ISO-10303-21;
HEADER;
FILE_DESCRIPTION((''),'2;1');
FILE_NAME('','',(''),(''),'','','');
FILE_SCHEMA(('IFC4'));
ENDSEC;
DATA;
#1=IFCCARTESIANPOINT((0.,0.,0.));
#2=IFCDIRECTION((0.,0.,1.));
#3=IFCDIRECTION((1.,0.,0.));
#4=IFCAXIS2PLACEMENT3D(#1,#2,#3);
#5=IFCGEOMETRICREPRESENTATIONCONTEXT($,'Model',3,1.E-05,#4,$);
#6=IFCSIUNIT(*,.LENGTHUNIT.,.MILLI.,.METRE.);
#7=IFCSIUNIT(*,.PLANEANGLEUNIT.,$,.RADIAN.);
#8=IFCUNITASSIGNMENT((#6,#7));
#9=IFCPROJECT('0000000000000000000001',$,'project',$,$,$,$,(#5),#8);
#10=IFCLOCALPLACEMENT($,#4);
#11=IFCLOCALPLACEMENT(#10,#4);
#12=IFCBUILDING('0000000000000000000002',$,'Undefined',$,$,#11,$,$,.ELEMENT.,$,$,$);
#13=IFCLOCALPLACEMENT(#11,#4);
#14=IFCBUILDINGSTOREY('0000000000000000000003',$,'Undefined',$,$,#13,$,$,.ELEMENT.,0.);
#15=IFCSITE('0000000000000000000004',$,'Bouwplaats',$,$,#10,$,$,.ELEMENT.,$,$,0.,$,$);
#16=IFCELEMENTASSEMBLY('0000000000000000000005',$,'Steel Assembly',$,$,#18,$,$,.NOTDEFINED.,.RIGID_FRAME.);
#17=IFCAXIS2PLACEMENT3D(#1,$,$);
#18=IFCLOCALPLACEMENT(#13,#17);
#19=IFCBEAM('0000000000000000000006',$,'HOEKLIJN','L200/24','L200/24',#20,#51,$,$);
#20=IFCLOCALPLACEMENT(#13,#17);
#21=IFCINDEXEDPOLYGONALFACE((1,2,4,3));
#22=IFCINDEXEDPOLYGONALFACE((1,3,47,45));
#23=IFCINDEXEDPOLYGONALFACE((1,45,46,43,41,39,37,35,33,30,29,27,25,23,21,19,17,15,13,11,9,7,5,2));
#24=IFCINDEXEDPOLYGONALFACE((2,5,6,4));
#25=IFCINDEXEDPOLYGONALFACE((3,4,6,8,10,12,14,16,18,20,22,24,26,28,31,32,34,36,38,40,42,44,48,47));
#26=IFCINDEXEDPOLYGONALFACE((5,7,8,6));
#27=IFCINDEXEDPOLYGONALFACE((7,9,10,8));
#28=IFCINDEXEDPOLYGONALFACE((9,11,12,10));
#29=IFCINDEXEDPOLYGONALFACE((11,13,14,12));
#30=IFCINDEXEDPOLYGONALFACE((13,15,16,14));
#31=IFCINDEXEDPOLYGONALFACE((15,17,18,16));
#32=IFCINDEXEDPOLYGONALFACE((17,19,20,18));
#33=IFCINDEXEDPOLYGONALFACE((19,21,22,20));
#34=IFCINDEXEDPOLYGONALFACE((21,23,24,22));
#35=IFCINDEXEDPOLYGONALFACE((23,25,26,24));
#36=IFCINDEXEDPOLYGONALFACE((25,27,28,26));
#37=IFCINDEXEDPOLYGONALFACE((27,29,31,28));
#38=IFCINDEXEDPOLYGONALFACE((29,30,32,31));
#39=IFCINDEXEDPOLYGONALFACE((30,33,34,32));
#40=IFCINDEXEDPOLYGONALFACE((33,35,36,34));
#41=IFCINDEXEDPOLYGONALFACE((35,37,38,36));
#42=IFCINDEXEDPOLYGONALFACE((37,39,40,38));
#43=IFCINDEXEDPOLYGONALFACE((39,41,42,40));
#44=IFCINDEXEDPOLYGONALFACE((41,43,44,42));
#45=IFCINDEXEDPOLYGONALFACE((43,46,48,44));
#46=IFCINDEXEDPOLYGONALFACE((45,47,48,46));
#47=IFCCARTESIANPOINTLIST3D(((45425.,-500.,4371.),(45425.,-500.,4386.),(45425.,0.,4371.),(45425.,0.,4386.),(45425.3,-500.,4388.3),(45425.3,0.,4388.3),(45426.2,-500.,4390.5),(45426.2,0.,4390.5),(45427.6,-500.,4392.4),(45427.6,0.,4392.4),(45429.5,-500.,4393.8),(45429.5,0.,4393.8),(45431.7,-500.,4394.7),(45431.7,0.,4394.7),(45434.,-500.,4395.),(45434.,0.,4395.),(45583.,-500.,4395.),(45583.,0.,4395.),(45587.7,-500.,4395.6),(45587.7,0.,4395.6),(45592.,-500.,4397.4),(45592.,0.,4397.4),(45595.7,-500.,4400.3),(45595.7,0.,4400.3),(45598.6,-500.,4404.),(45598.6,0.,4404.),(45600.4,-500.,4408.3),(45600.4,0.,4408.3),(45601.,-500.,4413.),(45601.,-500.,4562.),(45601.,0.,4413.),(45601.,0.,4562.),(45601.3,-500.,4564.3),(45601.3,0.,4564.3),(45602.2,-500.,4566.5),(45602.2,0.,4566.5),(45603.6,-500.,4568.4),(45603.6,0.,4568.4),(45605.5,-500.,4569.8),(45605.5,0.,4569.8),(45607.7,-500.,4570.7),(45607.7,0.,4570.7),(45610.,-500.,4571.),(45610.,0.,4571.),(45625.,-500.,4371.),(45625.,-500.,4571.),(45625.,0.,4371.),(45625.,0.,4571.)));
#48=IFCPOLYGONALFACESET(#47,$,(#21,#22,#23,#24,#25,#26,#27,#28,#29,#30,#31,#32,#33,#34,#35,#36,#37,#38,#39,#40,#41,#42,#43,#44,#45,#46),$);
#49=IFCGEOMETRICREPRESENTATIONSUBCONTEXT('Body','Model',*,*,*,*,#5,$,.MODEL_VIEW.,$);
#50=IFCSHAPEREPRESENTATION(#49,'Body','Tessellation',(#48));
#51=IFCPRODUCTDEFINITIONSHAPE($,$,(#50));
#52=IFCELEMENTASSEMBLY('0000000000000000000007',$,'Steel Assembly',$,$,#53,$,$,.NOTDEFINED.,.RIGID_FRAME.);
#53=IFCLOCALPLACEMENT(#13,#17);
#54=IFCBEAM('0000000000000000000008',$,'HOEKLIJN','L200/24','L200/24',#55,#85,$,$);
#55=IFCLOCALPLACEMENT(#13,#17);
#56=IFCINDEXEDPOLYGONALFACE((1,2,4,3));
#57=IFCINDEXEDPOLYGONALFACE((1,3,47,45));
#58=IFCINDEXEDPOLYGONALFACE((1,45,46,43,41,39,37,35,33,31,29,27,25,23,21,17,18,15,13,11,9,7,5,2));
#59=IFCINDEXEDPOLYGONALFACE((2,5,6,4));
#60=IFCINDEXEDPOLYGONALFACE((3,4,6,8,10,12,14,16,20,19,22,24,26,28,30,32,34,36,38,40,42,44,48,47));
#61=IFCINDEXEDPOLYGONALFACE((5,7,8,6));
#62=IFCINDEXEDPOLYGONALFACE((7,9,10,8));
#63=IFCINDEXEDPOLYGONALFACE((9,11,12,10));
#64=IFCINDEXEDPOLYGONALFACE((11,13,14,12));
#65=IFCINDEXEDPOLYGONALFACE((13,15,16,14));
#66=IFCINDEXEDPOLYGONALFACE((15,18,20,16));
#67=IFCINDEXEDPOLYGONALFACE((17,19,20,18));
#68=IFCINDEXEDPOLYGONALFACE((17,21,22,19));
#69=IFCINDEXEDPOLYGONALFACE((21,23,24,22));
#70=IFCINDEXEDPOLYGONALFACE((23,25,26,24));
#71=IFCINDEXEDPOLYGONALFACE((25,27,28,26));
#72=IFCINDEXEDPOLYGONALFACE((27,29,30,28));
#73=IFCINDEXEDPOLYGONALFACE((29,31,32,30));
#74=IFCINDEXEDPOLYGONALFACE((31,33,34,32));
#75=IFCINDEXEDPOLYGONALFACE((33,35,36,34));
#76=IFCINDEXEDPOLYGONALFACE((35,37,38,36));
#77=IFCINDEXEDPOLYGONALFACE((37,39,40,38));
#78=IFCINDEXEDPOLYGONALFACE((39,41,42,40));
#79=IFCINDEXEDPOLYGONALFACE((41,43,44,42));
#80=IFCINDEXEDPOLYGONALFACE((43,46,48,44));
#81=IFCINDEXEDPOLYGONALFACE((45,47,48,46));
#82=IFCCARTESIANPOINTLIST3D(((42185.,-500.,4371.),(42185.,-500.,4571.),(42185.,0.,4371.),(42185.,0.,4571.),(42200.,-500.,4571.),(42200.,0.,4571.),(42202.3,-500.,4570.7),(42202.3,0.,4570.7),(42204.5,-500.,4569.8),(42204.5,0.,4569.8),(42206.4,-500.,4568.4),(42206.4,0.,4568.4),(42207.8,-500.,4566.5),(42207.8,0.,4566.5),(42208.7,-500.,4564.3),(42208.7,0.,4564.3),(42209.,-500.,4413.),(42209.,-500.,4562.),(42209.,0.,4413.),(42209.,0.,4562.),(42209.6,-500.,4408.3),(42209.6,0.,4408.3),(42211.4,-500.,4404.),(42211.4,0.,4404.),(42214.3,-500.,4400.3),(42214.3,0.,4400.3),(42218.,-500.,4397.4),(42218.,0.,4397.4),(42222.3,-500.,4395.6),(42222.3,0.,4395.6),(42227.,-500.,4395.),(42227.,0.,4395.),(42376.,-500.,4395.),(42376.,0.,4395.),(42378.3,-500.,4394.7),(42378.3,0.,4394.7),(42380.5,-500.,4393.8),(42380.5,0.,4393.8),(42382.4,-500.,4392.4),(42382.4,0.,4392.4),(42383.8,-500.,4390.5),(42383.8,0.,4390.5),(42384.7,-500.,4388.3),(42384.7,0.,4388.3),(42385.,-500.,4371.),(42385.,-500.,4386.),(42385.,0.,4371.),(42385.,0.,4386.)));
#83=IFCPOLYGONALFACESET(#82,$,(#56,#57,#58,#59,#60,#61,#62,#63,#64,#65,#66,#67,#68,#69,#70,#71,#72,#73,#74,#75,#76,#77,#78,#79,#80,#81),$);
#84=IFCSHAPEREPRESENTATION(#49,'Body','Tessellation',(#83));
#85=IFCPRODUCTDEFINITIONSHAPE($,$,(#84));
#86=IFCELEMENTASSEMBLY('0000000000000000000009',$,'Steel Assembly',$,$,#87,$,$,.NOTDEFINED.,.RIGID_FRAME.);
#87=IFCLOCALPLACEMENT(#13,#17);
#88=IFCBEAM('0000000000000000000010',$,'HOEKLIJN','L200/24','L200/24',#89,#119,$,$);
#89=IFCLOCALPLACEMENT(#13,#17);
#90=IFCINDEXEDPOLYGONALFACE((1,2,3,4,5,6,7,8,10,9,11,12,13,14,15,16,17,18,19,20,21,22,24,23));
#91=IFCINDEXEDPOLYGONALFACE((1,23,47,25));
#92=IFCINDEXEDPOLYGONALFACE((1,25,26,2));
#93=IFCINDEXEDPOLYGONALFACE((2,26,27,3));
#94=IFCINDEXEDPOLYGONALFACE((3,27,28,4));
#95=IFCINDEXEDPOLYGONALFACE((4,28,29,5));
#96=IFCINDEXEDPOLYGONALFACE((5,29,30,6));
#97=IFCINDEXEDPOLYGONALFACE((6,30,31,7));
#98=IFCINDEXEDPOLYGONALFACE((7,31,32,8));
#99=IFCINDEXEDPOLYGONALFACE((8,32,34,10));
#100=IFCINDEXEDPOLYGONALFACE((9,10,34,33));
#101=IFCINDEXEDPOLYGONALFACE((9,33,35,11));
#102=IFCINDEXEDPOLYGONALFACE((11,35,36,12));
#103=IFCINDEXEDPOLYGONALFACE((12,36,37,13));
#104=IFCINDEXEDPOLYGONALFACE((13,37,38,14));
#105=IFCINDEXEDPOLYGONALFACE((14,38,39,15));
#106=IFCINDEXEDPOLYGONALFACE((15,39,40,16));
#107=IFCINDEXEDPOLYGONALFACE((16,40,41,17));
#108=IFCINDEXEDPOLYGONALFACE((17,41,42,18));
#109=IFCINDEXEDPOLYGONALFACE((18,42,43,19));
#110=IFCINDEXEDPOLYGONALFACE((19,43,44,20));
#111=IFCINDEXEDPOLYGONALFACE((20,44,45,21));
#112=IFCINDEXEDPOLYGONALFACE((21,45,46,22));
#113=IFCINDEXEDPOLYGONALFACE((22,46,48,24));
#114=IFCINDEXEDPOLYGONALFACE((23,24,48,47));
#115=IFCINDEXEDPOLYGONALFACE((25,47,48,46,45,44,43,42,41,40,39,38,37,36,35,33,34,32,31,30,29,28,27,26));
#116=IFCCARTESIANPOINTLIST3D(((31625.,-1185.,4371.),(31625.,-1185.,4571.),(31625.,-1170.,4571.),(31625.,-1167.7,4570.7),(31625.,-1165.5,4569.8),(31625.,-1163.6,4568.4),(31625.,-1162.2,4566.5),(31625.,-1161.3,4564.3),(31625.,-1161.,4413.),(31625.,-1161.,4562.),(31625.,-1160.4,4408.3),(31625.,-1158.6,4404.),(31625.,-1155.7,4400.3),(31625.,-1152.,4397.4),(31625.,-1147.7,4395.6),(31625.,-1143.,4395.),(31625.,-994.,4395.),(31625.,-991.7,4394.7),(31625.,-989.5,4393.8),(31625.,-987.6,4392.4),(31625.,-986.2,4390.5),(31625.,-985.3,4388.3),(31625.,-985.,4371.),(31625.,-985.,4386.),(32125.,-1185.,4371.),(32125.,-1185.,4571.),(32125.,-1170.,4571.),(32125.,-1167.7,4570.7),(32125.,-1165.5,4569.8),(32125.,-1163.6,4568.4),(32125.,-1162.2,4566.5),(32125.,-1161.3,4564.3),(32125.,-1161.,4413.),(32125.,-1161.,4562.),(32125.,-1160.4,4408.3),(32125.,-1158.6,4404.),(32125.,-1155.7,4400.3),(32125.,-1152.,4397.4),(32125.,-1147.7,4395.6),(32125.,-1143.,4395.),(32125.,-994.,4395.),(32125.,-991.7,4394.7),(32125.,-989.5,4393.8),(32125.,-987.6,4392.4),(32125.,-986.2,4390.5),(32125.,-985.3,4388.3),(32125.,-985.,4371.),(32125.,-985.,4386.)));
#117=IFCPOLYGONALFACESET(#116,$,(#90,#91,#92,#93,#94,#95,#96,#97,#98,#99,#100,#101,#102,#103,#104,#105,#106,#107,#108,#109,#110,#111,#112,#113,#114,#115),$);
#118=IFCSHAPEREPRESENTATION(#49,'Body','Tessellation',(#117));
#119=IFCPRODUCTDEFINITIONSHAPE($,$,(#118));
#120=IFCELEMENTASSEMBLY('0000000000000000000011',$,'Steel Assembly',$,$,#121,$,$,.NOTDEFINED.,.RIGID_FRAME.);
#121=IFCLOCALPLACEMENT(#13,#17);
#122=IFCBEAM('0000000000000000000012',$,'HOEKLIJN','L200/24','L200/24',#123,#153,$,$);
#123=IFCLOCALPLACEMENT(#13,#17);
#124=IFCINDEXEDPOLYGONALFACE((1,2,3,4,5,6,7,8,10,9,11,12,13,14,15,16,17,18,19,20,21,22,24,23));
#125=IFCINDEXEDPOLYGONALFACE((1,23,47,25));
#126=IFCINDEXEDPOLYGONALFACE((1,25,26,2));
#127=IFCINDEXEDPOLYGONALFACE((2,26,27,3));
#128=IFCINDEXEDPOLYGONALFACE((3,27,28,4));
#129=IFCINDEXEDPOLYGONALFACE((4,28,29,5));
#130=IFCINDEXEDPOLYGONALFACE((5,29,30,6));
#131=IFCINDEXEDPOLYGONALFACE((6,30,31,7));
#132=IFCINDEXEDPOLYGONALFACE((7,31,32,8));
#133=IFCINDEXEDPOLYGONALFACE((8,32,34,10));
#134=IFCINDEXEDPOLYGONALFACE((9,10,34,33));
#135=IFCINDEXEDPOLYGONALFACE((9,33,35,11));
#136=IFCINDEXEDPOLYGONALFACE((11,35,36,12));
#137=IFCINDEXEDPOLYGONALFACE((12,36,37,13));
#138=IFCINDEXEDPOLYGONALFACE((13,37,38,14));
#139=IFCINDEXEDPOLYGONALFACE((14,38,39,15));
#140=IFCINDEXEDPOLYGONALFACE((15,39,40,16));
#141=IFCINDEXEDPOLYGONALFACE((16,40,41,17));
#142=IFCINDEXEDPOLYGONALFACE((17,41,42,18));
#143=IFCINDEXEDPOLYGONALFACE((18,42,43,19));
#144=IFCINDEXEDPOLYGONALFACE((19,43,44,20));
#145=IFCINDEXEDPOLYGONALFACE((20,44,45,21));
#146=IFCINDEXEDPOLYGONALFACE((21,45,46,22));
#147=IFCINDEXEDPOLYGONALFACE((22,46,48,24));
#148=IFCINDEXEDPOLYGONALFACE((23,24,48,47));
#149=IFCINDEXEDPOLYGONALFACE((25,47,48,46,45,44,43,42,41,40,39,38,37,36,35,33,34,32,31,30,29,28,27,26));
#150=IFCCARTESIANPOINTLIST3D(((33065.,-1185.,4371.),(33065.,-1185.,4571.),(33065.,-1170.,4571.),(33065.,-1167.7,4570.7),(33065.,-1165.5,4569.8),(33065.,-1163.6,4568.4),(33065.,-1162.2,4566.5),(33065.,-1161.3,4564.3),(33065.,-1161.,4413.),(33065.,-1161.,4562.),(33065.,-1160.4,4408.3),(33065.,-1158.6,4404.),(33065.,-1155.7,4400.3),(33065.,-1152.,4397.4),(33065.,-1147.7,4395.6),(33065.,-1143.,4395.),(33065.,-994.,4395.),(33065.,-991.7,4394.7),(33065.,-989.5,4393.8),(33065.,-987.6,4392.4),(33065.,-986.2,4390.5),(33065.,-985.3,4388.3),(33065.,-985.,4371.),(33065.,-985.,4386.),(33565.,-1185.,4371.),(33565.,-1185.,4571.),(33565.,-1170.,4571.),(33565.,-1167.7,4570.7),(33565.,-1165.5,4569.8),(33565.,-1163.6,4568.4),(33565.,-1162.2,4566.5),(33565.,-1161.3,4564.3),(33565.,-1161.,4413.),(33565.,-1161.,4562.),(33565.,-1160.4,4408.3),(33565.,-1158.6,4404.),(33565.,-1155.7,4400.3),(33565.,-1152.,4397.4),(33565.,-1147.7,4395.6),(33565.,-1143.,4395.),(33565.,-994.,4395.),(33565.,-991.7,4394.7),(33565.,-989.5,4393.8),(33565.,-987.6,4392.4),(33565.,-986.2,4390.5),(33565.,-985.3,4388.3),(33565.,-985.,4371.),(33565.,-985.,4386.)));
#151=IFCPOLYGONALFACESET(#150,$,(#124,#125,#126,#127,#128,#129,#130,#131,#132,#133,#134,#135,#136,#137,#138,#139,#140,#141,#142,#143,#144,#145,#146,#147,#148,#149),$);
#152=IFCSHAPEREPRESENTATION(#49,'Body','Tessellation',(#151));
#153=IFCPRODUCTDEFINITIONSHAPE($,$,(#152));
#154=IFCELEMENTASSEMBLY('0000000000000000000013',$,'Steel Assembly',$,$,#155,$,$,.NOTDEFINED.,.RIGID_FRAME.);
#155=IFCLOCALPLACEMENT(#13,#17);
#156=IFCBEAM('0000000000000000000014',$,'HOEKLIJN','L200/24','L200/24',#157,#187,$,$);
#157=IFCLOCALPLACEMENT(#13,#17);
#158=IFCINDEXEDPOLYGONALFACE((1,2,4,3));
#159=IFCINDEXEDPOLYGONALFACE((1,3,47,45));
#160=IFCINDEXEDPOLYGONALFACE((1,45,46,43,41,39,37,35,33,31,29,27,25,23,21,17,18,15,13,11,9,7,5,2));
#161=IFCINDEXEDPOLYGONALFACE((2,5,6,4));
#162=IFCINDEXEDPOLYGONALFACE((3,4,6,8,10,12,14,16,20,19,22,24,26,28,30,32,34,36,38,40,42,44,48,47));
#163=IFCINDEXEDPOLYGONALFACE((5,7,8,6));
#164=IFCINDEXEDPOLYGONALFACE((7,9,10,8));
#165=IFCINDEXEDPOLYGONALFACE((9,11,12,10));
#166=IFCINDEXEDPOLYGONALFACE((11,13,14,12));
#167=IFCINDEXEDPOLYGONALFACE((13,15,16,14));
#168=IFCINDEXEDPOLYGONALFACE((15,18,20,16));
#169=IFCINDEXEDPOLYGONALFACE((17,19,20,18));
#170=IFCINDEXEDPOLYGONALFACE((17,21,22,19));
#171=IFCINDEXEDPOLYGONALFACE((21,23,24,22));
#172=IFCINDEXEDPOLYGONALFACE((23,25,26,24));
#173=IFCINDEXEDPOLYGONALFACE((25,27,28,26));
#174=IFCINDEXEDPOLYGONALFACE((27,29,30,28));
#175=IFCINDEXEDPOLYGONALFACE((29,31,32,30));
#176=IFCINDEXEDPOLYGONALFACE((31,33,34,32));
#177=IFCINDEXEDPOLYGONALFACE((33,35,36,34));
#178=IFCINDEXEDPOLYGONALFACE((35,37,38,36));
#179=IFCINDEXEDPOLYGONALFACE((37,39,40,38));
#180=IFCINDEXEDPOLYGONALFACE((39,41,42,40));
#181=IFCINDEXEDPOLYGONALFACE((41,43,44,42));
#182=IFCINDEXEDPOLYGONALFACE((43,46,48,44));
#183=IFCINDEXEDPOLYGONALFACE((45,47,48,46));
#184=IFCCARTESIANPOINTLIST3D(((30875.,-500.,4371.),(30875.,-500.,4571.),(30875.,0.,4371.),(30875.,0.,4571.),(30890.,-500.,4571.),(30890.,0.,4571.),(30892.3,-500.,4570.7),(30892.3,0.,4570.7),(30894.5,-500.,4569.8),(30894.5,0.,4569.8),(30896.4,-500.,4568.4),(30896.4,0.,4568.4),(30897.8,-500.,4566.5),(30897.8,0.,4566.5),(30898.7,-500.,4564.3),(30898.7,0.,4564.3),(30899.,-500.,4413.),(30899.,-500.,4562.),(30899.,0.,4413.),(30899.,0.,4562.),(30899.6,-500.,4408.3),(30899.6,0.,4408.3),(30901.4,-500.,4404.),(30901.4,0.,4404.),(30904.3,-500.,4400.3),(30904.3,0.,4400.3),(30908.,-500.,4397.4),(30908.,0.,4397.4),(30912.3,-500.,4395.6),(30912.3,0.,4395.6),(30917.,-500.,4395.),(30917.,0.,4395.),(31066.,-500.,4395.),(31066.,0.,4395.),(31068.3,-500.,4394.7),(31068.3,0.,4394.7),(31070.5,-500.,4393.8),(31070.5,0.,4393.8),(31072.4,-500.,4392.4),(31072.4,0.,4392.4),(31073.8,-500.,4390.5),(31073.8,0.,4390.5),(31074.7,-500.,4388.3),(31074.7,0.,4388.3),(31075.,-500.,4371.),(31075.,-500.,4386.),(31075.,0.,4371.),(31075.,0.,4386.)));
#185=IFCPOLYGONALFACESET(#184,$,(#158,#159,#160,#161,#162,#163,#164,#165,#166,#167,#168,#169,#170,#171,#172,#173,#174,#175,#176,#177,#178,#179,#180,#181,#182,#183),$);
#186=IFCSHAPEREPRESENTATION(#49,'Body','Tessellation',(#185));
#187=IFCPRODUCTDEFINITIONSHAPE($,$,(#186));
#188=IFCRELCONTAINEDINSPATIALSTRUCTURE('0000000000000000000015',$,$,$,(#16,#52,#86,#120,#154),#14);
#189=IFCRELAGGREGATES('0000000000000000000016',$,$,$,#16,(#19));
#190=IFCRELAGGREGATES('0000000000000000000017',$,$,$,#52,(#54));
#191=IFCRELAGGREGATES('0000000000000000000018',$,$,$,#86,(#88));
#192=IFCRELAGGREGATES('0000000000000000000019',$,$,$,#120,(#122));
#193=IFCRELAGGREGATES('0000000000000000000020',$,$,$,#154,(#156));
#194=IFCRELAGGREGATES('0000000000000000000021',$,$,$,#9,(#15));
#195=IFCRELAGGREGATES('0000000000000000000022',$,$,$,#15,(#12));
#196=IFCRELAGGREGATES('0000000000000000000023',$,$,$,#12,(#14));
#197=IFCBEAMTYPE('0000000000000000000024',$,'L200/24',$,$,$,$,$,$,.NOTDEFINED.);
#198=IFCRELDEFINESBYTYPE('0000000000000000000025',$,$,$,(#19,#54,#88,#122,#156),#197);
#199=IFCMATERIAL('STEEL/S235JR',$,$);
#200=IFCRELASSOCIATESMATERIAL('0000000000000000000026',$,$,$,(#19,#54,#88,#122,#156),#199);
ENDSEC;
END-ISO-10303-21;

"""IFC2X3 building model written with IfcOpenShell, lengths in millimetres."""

from ifc_helpers import new_model, si_unit, frame, origin_with_axes, origin_2d_with_axis, place, context, subcontext, project, spatial, l_section, extrude, material, type_object, element, aggregate, save


model = new_model("IFC2X3")

# Units and contexts
model_context = context("Model", 3, precision=1e-05, world=origin_with_axes())
body_context = subcontext(model_context, "Body", "Model", "MODEL_VIEW")
ifc_project = project(units=[si_unit("LENGTHUNIT", "METRE", prefix="MILLI"), si_unit("PLANEANGLEUNIT", "RADIAN")], contexts=[model_context])

# Site, building, storey
site_placement = place(None, origin_with_axes())
site = spatial("IfcSite", under=ifc_project, at=site_placement, Name="Bouwplaats", CompositionType="ELEMENT", RefElevation=0.0)
building_placement = place(site_placement, origin_with_axes())
building = spatial("IfcBuilding", under=site, at=building_placement, Name="Undefined", CompositionType="ELEMENT")
storey_placement = place(building_placement, origin_with_axes())
storey = spatial("IfcBuildingStorey", under=building, at=storey_placement, Name="Undefined", CompositionType="ELEMENT", Elevation=0.0)

# Shared definitions
ifc_material_1 = material(Name="STEEL/S235JR")

# Element assemblies, beams
beam_type_1 = type_object("IfcBeamType", Name="L200/24", PredefinedType="NOTDEFINED")
assembly_1_placement = place(storey_placement, origin_with_axes())
assembly_1 = element("IfcElementAssembly", 1, at=assembly_1_placement, inside=storey, Name="Steel Assembly", AssemblyPlace="NOTDEFINED", PredefinedType="RIGID_FRAME")
beam_1_placement = place(assembly_1_placement, frame((45525.0, -500.0, 4471.0), z_axis=(-1.0, 0.0, 0.0), x_axis=(0.0, 1.0, 0.0)))
beam_1 = element("IfcBeam", 2, at=beam_1_placement, type_object=beam_type_1, material=ifc_material_1, Name="HOEKLIJN", Description="L200/24", ObjectType="L200/24", context=body_context, shape_type="SweptSolid", body=[
    extrude(l_section(Depth=200.0, Width=200.0, Thickness=24.0, FilletRadius=18.0, EdgeRadius=9.0, at=origin_2d_with_axis()), frame((500.0, 0.0, 0.0), z_axis=(-1.0, 0.0, 0.0), x_axis=(0.0, -1.0, 0.0)), (0.0, 0.0, 1.0), 500.0),
])
aggregate(assembly_1, [beam_1])
assembly_2_placement = place(storey_placement, origin_with_axes())
assembly_2 = element("IfcElementAssembly", 3, at=assembly_2_placement, inside=storey, Name="Steel Assembly", AssemblyPlace="NOTDEFINED", PredefinedType="RIGID_FRAME")
beam_2_placement = place(assembly_2_placement, frame((42285.0, 0.0, 4471.0), z_axis=(1.0, 0.0, 0.0), x_axis=(0.0, -1.0, 0.0)))
beam_2 = element("IfcBeam", 4, at=beam_2_placement, type_object=beam_type_1, material=ifc_material_1, Name="HOEKLIJN", Description="L200/24", ObjectType="L200/24", context=body_context, shape_type="SweptSolid", body=[
    extrude(l_section(Depth=200.0, Width=200.0, Thickness=24.0, FilletRadius=18.0, EdgeRadius=9.0, at=origin_2d_with_axis()), frame((500.0, 0.0, 0.0), z_axis=(-1.0, 0.0, 0.0), x_axis=(0.0, -1.0, 0.0)), (0.0, 0.0, 1.0), 500.0),
])
aggregate(assembly_2, [beam_2])
assembly_3_placement = place(storey_placement, origin_with_axes())
assembly_3 = element("IfcElementAssembly", 5, at=assembly_3_placement, inside=storey, Name="Steel Assembly", AssemblyPlace="NOTDEFINED", PredefinedType="RIGID_FRAME")
beam_3_placement = place(assembly_3_placement, frame((31625.0, -1085.0, 4471.0), z_axis=(0.0, 1.0, 0.0), x_axis=(1.0, 0.0, 0.0)))
beam_3 = element("IfcBeam", 6, at=beam_3_placement, type_object=beam_type_1, material=ifc_material_1, Name="HOEKLIJN", Description="L200/24", ObjectType="L200/24", context=body_context, shape_type="SweptSolid", body=[
    extrude(l_section(Depth=200.0, Width=200.0, Thickness=24.0, FilletRadius=18.0, EdgeRadius=9.0, at=origin_2d_with_axis()), frame((500.0, 0.0, 0.0), z_axis=(-1.0, 0.0, 0.0), x_axis=(0.0, -1.0, 0.0)), (0.0, 0.0, 1.0), 500.0),
])
aggregate(assembly_3, [beam_3])
assembly_4_placement = place(storey_placement, origin_with_axes())
assembly_4 = element("IfcElementAssembly", 7, at=assembly_4_placement, inside=storey, Name="Steel Assembly", AssemblyPlace="NOTDEFINED", PredefinedType="RIGID_FRAME")
beam_4_placement = place(assembly_4_placement, frame((33065.0, -1085.0, 4471.0), z_axis=(0.0, 1.0, 0.0), x_axis=(1.0, 0.0, 0.0)))
beam_4 = element("IfcBeam", 8, at=beam_4_placement, type_object=beam_type_1, material=ifc_material_1, Name="HOEKLIJN", Description="L200/24", ObjectType="L200/24", context=body_context, shape_type="SweptSolid", body=[
    extrude(l_section(Depth=200.0, Width=200.0, Thickness=24.0, FilletRadius=18.0, EdgeRadius=9.0, at=origin_2d_with_axis()), frame((500.0, 0.0, 0.0), z_axis=(-1.0, 0.0, 0.0), x_axis=(0.0, -1.0, 0.0)), (0.0, 0.0, 1.0), 500.0),
])
aggregate(assembly_4, [beam_4])
assembly_5_placement = place(storey_placement, origin_with_axes())
assembly_5 = element("IfcElementAssembly", 9, at=assembly_5_placement, inside=storey, Name="Steel Assembly", AssemblyPlace="NOTDEFINED", PredefinedType="RIGID_FRAME")
beam_5_placement = place(assembly_5_placement, frame((30975.0, 0.0, 4471.0), z_axis=(1.0, 0.0, 0.0), x_axis=(0.0, -1.0, 0.0)))
beam_5 = element("IfcBeam", 10, at=beam_5_placement, type_object=beam_type_1, material=ifc_material_1, Name="HOEKLIJN", Description="L200/24", ObjectType="L200/24", context=body_context, shape_type="SweptSolid", body=[
    extrude(l_section(Depth=200.0, Width=200.0, Thickness=24.0, FilletRadius=18.0, EdgeRadius=9.0, at=origin_2d_with_axis()), frame((500.0, 0.0, 0.0), z_axis=(-1.0, 0.0, 0.0), x_axis=(0.0, -1.0, 0.0)), (0.0, 0.0, 1.0), 500.0),
])
aggregate(assembly_5, [beam_5])

save(model, "model.ifc")
